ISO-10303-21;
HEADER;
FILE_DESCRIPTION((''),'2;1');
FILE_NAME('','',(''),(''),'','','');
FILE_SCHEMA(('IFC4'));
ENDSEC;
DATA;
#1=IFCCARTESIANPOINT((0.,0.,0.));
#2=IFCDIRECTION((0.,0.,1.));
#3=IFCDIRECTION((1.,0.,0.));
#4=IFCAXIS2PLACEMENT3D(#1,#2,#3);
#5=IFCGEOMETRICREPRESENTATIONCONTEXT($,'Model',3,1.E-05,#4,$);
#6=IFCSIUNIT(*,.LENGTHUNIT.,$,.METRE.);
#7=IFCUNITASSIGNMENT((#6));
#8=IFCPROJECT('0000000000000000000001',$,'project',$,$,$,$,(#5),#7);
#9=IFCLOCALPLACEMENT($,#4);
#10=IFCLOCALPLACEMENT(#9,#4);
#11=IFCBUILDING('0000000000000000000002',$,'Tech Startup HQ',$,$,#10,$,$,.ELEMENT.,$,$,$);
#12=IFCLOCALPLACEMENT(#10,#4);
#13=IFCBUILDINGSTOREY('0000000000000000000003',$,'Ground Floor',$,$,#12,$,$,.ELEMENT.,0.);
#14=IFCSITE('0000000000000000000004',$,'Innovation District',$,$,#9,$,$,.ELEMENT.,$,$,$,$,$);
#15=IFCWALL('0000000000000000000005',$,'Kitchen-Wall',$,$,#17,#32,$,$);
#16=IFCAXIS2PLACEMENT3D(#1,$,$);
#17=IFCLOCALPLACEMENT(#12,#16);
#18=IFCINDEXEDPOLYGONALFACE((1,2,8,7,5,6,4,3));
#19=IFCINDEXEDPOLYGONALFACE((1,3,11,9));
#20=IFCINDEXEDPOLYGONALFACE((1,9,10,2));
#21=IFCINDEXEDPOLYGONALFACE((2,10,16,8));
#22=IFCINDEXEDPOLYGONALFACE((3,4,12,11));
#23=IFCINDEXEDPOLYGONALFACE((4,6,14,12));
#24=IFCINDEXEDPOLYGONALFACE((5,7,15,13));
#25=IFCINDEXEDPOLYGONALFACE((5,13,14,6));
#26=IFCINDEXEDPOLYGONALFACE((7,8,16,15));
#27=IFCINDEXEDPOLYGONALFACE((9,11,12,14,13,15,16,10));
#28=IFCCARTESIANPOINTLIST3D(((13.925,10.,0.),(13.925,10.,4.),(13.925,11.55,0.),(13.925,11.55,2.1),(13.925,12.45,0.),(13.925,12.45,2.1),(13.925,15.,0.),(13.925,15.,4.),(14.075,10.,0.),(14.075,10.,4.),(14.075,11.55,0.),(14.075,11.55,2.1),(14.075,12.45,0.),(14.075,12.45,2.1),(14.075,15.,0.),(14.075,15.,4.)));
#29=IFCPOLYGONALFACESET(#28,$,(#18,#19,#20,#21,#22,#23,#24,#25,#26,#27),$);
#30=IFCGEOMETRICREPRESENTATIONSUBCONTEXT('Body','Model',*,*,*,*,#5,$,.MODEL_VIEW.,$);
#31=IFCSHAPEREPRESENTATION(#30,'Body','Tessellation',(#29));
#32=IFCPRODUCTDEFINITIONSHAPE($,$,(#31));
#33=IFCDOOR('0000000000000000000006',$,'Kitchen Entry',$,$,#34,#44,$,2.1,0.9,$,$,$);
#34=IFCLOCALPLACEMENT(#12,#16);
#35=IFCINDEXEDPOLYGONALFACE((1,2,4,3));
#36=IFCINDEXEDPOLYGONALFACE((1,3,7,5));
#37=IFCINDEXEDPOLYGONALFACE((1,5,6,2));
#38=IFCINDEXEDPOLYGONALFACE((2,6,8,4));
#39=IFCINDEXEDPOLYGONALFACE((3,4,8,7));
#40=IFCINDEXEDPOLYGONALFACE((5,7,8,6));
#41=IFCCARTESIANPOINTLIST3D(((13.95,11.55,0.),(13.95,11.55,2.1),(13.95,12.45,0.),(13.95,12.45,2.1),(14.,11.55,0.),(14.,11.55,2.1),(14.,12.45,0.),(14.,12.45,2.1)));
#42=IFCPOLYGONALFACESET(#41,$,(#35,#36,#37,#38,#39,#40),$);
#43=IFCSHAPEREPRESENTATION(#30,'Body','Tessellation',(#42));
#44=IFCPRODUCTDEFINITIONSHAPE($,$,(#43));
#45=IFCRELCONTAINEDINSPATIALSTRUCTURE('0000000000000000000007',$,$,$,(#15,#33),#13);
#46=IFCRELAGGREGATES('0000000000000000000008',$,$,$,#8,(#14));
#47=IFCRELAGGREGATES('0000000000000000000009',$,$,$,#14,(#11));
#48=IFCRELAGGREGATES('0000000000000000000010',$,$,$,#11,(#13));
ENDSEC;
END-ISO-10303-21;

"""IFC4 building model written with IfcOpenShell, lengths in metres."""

from ifc_helpers import new_model, si_unit, origin_with_axes, place, context, subcontext, project, spatial, polyline, outline, extrude, element, fill, save


model = new_model("IFC4")

# Units and contexts
model_context = context("Model", 3, precision=1e-05, world=origin_with_axes())
body_context = subcontext(model_context, "Body", "Model", "MODEL_VIEW")
ifc_project = project(units=[si_unit("LENGTHUNIT", "METRE")], contexts=[model_context])

# Site, building, storey
site_placement = place(None, origin_with_axes())
site = spatial("IfcSite", under=ifc_project, at=site_placement, Name="Innovation District", CompositionType="ELEMENT")
building_placement = place(site_placement, origin_with_axes())
building = spatial("IfcBuilding", under=site, at=building_placement, Name="Tech Startup HQ", CompositionType="ELEMENT")
storey_placement = place(building_placement, origin_with_axes())
storey = spatial("IfcBuildingStorey", under=building, at=storey_placement, Name="Ground Floor", CompositionType="ELEMENT", Elevation=0.0)

# Wall, opening, door
wall_1_placement = place(storey_placement, origin_with_axes())
wall_1 = element("IfcWall", 1, at=wall_1_placement, inside=storey, Name="Kitchen-Wall", context=body_context, shape_type="SweptSolid", body=[
    extrude(outline(polyline([(14.075, 10.0, 0.0), (14.075, 15.0, 0.0), (13.925, 15.0, 0.0), (13.925, 10.0, 0.0), (14.075, 10.0, 0.0)])), None, (0.0, 0.0, 1.0), 4.0),
])
opening_1_placement = place(storey_placement, origin_with_axes())
opening_1 = element("IfcOpeningElement", 2, at=opening_1_placement, inside=storey, cuts=wall_1, context=body_context, shape_type="SweptSolid", body=[
    extrude(outline(polyline([(14.15, 11.55, 0.0), (14.15, 12.45, 0.0), (13.85, 12.45, 0.0), (13.85, 11.55, 0.0), (14.15, 11.55, 0.0)])), None, (0.0, 0.0, 1.0), 2.1),
])
door_1_placement = place(storey_placement, origin_with_axes())
door_1 = element("IfcDoor", 3, at=door_1_placement, inside=storey, Name="Kitchen Entry", OverallHeight=2.1, OverallWidth=0.9, context=body_context, shape_type="SweptSolid", body=[
    extrude(outline(polyline([(14.0, 11.55, 0.0), (14.0, 12.45, 0.0), (13.95, 12.45, 0.0), (13.95, 11.55, 0.0), (14.0, 11.55, 0.0)])), None, (0.0, 0.0, 1.0), 2.1),
])
fill(opening_1, door_1)

save(model, "model.ifc")
